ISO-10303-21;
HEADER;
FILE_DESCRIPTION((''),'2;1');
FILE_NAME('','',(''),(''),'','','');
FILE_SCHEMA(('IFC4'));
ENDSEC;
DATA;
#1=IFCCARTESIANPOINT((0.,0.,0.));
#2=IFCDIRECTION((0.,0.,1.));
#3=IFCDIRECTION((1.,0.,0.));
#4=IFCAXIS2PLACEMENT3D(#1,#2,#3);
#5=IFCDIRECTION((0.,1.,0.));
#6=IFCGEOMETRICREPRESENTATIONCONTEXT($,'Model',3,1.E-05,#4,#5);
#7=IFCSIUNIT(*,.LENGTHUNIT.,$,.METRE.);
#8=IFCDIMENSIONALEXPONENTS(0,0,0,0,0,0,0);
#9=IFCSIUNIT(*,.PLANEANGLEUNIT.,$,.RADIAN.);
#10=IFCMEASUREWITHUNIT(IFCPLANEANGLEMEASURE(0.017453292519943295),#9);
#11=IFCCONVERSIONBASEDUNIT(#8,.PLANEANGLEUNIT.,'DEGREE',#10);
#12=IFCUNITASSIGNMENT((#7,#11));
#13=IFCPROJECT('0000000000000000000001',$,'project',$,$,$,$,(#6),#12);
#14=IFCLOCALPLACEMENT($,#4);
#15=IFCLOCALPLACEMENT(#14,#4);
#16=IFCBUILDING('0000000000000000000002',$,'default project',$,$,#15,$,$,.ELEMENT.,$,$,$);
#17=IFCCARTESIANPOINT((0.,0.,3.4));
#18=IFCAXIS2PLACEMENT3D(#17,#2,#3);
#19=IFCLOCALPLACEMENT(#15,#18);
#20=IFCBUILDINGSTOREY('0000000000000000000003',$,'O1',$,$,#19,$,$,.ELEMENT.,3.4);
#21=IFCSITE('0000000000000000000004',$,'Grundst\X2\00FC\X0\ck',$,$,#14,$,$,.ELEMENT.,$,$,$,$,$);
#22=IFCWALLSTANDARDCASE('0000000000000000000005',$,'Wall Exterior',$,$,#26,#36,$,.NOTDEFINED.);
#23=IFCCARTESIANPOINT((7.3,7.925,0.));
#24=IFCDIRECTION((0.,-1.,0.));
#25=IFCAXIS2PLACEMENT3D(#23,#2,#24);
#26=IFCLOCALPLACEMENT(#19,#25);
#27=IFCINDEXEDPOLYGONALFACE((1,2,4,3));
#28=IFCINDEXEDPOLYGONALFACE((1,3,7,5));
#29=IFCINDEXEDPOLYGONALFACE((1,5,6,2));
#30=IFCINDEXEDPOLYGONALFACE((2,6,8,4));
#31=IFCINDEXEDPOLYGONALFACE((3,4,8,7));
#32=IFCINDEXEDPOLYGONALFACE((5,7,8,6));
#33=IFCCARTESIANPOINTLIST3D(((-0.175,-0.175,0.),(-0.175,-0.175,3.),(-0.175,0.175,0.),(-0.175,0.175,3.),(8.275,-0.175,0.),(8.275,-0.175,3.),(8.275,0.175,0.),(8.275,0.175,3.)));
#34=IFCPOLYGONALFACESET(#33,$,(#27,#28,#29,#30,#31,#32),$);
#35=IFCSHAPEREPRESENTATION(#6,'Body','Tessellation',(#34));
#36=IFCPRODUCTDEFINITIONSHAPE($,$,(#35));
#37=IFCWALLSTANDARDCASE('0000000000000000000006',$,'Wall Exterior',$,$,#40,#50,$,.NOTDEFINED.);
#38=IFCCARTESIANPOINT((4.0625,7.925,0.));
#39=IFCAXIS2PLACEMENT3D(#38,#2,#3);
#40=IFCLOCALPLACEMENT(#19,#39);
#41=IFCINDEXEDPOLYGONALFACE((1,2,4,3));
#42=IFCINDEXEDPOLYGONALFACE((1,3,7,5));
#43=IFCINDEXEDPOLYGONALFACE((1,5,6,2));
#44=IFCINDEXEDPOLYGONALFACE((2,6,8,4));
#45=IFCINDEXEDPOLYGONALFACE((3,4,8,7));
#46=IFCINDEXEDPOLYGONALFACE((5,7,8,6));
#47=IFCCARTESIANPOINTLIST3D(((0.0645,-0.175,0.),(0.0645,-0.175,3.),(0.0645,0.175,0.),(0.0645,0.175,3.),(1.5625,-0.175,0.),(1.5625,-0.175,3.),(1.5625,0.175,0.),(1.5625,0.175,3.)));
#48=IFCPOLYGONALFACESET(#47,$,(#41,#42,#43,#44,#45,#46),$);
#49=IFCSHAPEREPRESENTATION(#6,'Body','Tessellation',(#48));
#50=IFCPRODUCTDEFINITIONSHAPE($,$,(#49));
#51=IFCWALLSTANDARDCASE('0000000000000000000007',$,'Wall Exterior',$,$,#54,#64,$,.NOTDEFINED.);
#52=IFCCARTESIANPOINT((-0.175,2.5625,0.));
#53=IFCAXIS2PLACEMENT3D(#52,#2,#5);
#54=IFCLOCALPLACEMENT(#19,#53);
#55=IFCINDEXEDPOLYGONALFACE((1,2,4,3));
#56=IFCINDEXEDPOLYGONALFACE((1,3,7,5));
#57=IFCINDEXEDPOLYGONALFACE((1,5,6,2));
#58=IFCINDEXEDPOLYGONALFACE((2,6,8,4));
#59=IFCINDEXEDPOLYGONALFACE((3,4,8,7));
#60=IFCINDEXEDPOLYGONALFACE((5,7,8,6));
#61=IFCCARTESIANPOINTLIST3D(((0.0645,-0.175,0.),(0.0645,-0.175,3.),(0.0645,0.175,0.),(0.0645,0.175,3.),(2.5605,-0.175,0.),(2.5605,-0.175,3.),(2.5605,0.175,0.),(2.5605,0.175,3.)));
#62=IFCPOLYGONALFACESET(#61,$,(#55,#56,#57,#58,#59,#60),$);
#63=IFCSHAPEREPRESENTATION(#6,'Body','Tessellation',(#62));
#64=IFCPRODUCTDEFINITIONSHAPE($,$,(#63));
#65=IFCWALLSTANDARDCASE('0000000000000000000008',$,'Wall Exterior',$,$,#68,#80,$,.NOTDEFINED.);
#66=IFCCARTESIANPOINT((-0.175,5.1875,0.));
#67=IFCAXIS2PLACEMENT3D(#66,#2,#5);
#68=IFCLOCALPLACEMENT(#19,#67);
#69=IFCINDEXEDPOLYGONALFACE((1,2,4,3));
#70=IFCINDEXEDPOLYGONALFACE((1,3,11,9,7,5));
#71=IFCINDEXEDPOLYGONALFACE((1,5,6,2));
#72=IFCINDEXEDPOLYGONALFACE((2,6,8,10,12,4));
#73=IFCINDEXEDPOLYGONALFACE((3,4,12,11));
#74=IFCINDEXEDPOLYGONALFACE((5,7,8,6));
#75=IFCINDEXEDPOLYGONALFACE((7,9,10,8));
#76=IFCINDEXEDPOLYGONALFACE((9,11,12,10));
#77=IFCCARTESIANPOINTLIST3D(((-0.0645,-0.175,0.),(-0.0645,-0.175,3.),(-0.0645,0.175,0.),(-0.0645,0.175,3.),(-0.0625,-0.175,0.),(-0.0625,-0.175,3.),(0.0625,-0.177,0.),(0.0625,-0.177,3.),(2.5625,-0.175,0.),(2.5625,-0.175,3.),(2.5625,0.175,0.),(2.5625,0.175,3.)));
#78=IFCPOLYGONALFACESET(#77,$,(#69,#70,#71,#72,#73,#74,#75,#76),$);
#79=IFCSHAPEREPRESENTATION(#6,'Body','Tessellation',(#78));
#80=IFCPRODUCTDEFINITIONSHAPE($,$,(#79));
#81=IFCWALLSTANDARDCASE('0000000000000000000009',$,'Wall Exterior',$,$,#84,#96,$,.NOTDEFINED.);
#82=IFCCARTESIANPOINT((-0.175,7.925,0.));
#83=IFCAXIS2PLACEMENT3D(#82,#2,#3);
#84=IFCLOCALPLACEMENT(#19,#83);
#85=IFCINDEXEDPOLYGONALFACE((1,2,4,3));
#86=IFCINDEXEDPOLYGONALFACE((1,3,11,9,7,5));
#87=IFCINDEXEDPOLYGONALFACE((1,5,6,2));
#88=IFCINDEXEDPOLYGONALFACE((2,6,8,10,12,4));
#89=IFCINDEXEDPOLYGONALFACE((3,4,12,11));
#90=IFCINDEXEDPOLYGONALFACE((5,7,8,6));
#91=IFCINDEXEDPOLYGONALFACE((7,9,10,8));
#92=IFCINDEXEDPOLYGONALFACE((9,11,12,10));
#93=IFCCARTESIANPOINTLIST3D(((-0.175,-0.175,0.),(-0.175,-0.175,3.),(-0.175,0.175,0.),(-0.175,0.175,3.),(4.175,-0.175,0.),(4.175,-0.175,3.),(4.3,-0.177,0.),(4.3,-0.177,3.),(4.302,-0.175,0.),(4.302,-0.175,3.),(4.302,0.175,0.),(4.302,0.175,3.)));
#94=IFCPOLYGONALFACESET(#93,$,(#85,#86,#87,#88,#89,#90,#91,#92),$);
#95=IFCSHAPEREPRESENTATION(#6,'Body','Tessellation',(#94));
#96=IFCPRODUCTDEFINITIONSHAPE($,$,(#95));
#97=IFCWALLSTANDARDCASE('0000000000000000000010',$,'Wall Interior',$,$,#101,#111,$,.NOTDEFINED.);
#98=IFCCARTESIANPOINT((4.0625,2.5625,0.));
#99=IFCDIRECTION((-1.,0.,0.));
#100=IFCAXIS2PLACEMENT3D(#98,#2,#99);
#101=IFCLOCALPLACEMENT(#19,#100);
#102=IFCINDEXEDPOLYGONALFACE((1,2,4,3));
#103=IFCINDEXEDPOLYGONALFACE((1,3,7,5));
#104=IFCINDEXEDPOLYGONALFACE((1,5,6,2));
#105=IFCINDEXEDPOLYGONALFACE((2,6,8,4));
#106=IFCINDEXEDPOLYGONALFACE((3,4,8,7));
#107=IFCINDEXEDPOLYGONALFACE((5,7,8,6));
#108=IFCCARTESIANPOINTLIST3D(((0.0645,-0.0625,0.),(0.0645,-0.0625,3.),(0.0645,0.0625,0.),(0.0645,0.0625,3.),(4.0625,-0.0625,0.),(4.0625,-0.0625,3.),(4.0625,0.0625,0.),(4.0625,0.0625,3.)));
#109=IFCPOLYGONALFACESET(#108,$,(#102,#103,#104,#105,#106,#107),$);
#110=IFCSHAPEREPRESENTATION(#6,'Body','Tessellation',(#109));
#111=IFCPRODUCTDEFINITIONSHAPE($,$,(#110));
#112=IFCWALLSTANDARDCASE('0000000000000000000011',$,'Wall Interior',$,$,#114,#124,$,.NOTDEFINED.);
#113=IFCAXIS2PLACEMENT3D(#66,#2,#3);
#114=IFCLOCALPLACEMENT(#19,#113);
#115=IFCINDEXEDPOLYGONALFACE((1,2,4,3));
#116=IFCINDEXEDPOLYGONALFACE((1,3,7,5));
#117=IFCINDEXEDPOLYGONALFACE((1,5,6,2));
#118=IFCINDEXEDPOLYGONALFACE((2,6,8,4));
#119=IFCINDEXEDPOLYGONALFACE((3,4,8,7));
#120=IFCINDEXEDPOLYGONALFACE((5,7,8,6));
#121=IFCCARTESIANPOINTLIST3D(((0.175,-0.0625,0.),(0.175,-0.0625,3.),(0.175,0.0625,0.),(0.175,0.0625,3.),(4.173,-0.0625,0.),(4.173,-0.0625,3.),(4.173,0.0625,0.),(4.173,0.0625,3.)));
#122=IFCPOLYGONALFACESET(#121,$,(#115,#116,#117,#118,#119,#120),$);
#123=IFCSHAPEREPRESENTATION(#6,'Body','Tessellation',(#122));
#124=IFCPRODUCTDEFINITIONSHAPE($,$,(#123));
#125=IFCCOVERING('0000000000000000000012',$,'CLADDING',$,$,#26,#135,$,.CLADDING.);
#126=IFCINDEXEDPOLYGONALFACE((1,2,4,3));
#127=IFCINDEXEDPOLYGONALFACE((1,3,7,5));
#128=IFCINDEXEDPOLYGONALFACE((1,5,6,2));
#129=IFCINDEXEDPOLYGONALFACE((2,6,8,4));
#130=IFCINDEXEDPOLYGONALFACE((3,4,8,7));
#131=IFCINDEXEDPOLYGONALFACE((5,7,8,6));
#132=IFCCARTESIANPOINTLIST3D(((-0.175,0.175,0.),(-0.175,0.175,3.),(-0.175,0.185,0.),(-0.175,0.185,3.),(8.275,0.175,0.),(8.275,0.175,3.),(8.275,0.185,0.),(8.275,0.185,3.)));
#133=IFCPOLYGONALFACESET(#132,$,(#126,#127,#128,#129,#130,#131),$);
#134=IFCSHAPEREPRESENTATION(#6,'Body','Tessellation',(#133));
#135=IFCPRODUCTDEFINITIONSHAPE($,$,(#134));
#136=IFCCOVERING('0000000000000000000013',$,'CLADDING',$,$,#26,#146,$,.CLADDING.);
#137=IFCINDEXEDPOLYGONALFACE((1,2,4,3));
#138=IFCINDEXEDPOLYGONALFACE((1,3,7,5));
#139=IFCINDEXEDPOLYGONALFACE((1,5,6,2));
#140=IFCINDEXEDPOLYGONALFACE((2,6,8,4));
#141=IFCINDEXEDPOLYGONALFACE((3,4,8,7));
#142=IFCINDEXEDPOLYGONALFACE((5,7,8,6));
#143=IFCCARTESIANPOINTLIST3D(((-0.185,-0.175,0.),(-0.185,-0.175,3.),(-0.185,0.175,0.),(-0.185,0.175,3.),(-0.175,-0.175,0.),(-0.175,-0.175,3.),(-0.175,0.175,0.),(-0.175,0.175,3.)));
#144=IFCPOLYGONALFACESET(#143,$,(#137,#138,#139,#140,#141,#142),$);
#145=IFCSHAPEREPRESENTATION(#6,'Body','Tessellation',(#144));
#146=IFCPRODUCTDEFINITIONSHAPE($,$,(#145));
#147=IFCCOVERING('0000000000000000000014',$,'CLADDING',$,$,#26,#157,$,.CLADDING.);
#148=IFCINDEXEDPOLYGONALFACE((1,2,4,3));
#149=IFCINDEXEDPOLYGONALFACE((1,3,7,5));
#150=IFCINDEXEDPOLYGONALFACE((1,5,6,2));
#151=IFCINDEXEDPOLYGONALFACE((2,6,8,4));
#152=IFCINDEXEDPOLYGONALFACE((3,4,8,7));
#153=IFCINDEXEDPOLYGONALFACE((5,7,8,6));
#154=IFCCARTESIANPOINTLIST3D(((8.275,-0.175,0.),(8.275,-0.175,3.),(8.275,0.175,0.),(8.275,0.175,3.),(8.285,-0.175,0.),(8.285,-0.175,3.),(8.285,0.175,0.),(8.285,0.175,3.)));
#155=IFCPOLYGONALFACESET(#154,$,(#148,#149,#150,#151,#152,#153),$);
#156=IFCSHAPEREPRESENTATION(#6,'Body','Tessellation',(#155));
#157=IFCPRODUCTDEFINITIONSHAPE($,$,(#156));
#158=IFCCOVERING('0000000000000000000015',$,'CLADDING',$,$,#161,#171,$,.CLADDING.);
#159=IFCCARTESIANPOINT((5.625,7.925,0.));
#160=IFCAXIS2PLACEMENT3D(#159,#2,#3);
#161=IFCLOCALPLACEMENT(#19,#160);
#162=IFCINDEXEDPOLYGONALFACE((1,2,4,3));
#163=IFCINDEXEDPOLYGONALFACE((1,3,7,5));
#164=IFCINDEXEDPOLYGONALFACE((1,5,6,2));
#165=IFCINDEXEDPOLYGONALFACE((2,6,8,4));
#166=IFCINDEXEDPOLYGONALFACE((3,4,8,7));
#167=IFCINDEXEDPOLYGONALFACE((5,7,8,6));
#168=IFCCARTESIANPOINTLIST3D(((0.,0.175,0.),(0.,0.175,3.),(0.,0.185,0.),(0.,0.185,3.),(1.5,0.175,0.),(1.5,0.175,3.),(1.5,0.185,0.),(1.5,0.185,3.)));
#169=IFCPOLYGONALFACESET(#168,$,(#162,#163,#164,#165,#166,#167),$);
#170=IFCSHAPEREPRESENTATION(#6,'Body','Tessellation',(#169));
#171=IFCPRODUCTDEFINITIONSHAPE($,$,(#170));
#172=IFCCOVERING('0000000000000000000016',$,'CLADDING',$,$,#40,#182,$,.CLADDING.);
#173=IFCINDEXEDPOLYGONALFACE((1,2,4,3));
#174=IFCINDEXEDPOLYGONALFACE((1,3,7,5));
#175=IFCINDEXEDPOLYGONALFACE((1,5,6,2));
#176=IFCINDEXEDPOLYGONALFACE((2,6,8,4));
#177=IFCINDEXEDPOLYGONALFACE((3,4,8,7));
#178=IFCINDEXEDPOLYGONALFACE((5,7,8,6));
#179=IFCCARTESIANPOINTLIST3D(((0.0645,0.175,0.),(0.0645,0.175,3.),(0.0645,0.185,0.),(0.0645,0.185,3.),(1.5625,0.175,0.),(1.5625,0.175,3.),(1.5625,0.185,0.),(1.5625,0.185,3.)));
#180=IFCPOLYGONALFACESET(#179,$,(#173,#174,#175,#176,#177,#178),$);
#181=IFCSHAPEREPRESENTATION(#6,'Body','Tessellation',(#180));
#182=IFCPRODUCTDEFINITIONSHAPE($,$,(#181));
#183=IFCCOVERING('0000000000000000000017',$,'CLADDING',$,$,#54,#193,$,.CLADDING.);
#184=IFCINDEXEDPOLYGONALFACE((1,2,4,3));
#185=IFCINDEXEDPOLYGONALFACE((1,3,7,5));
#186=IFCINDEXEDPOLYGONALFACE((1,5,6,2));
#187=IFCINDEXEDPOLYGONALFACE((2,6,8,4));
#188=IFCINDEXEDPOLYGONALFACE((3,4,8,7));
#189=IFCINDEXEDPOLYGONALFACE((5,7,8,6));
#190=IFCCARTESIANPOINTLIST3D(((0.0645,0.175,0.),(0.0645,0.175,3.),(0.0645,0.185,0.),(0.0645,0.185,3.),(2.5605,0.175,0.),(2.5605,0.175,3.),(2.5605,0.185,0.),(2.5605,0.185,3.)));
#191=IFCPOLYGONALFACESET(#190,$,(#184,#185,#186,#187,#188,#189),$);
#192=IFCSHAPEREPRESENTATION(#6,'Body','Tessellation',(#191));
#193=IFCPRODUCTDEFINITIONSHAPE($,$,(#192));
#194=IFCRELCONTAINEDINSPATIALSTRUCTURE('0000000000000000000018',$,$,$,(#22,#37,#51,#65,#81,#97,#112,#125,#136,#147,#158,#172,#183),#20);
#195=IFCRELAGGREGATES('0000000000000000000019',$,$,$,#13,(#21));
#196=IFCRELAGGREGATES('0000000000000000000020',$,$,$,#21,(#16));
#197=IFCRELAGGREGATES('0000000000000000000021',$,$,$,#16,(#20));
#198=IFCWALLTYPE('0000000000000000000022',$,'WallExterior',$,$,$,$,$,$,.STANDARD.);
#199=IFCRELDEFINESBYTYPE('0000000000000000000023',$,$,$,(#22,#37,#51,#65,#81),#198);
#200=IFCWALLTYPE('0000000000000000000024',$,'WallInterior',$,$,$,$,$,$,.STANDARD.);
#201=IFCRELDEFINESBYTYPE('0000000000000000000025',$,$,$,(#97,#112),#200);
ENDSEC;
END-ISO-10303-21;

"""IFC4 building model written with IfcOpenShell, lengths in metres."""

from ifc_helpers import new_model, entity, si_unit, converted_unit, direction, frame, origin_with_axes, place, context, project, spatial, polyline, outline, extrude, type_object, element, save


model = new_model("IFC4")

# Units and contexts
model_context = context("Model", 3, precision=1e-05, world=origin_with_axes(), true_north=direction((0.0, 1.0, 0.0)))
ifc_project = project(units=[si_unit("LENGTHUNIT", "METRE"), converted_unit("PLANEANGLEUNIT", "DEGREE", entity("IfcPlaneAngleMeasure", 0.017453292519943295), si_unit("PLANEANGLEUNIT", "RADIAN"), dimensions=[0, 0, 0, 0, 0, 0, 0])], contexts=[model_context])

# Site, building, storey
site_placement = place(None, origin_with_axes())
site = spatial("IfcSite", under=ifc_project, at=site_placement, Name="Grundstück", CompositionType="ELEMENT")
building_placement = place(site_placement, origin_with_axes())
building = spatial("IfcBuilding", under=site, at=building_placement, Name="default project", CompositionType="ELEMENT")
placement_1 = place(building_placement, frame((0.0, 0.0, 3.4), z_axis=(0.0, 0.0, 1.0), x_axis=(1.0, 0.0, 0.0)))
storey = spatial("IfcBuildingStorey", under=building, at=placement_1, Name="O1", CompositionType="ELEMENT", Elevation=3.4)

# Walls
wall_type_1 = type_object("IfcWallType", Name="WallExterior", PredefinedType="STANDARD")
placement_2 = place(placement_1, frame((7.3, 7.925, 0.0), z_axis=(0.0, 0.0, 1.0), x_axis=(0.0, -1.0, 0.0)))
element("IfcWallStandardCase", 1, at=placement_2, inside=storey, type_object=wall_type_1, Name="Wall Exterior", PredefinedType="NOTDEFINED", context=model_context, shape_type="SweptSolid", body=[
    extrude(outline(polyline([(8.275, 0.175), (-0.175, 0.175), (-0.175, -0.175), (8.275, -0.175), (8.275, 0.175)])), origin_with_axes(), (0.0, 0.0, 1.0), 3.0),
])
placement_3 = place(placement_1, frame((5.625, 7.925, 0.0), z_axis=(0.0, 0.0, 1.0), x_axis=(1.0, 0.0, 0.0)))
placement_4 = place(placement_1, frame((4.0625, 7.925, 0.0), z_axis=(0.0, 0.0, 1.0), x_axis=(1.0, 0.0, 0.0)))
element("IfcWallStandardCase", 2, at=placement_4, inside=storey, type_object=wall_type_1, Name="Wall Exterior", PredefinedType="NOTDEFINED", context=model_context, shape_type="SweptSolid", body=[
    extrude(outline(polyline([(1.5625, 0.175), (0.0645, 0.175), (0.0645, -0.175), (1.5625, -0.175), (1.5625, 0.175)])), origin_with_axes(), (0.0, 0.0, 1.0), 3.0),
])
placement_5 = place(placement_1, frame((-0.175, 2.5625, 0.0), z_axis=(0.0, 0.0, 1.0), x_axis=(0.0, 1.0, 0.0)))
element("IfcWallStandardCase", 3, at=placement_5, inside=storey, type_object=wall_type_1, Name="Wall Exterior", PredefinedType="NOTDEFINED", context=model_context, shape_type="SweptSolid", body=[
    extrude(outline(polyline([(0.0645, -0.175), (2.5605, -0.175), (2.5605, 0.175), (0.0645, 0.175), (0.0645, -0.175)])), origin_with_axes(), (0.0, 0.0, 1.0), 3.0),
])
placement_6 = place(placement_1, frame((-0.175, 5.1875, 0.0), z_axis=(0.0, 0.0, 1.0), x_axis=(0.0, 1.0, 0.0)))
element("IfcWallStandardCase", 4, at=placement_6, inside=storey, type_object=wall_type_1, Name="Wall Exterior", PredefinedType="NOTDEFINED", context=model_context, shape_type="SweptSolid", body=[
    extrude(outline(polyline([(-0.0625, -0.175), (0.0625, -0.177), (2.5625, -0.175), (2.5625, 0.175), (-0.0645, 0.175), (-0.0645, -0.175), (-0.0625, -0.175)])), origin_with_axes(), (0.0, 0.0, 1.0), 3.0),
])
placement_7 = place(placement_1, frame((-0.175, 7.925, 0.0), z_axis=(0.0, 0.0, 1.0), x_axis=(1.0, 0.0, 0.0)))
element("IfcWallStandardCase", 5, at=placement_7, inside=storey, type_object=wall_type_1, Name="Wall Exterior", PredefinedType="NOTDEFINED", context=model_context, shape_type="SweptSolid", body=[
    extrude(outline(polyline([(-0.175, 0.175), (-0.175, -0.175), (4.175, -0.175), (4.3, -0.177), (4.302, -0.175), (4.302, 0.175), (-0.175, 0.175)])), origin_with_axes(), (0.0, 0.0, 1.0), 3.0),
])
wall_type_2 = type_object("IfcWallType", Name="WallInterior", PredefinedType="STANDARD")
wall_1_placement = place(placement_1, frame((4.0625, 2.5625, 0.0), z_axis=(0.0, 0.0, 1.0), x_axis=(-1.0, 0.0, 0.0)))
element("IfcWallStandardCase", 6, at=wall_1_placement, inside=storey, type_object=wall_type_2, Name="Wall Interior", PredefinedType="NOTDEFINED", context=model_context, shape_type="SweptSolid", body=[
    extrude(outline(polyline([(0.0645, -0.0625), (4.0625, -0.0625), (4.0625, 0.0625), (0.0645, 0.0625), (0.0645, -0.0625)])), origin_with_axes(), (0.0, 0.0, 1.0), 3.0),
])
wall_2_placement = place(placement_1, frame((-0.175, 5.1875, 0.0), z_axis=(0.0, 0.0, 1.0), x_axis=(1.0, 0.0, 0.0)))
element("IfcWallStandardCase", 7, at=wall_2_placement, inside=storey, type_object=wall_type_2, Name="Wall Interior", PredefinedType="NOTDEFINED", context=model_context, shape_type="SweptSolid", body=[
    extrude(outline(polyline([(4.173, 0.0625), (0.175, 0.0625), (0.175, -0.0625), (4.173, -0.0625), (4.173, 0.0625)])), origin_with_axes(), (0.0, 0.0, 1.0), 3.0),
])

# Coverings
element("IfcCovering", 8, at=placement_2, inside=storey, Name="CLADDING", PredefinedType="CLADDING", context=model_context, shape_type="SweptSolid", body=[
    extrude(outline(polyline([(8.275, 0.185), (-0.175, 0.185), (-0.175, 0.175), (8.275, 0.175), (8.275, 0.185)])), origin_with_axes(), (0.0, 0.0, 1.0), 3.0),
])
element("IfcCovering", 9, at=placement_2, inside=storey, Name="CLADDING", PredefinedType="CLADDING", context=model_context, shape_type="SweptSolid", body=[
    extrude(outline(polyline([(-0.185, 0.175), (-0.185, -0.175), (-0.175, -0.175), (-0.175, 0.175), (-0.185, 0.175)])), origin_with_axes(), (0.0, 0.0, 1.0), 3.0),
])
element("IfcCovering", 10, at=placement_2, inside=storey, Name="CLADDING", PredefinedType="CLADDING", context=model_context, shape_type="SweptSolid", body=[
    extrude(outline(polyline([(8.285, -0.175), (8.285, 0.175), (8.275, 0.175), (8.275, -0.175), (8.285, -0.175)])), origin_with_axes(), (0.0, 0.0, 1.0), 3.0),
])
element("IfcCovering", 11, at=placement_3, inside=storey, Name="CLADDING", PredefinedType="CLADDING", context=model_context, shape_type="SweptSolid", body=[
    extrude(outline(polyline([(1.5, 0.185), (0.0, 0.185), (0.0, 0.175), (1.5, 0.175), (1.5, 0.185)])), origin_with_axes(), (0.0, 0.0, 1.0), 3.0),
])
element("IfcCovering", 12, at=placement_4, inside=storey, Name="CLADDING", PredefinedType="CLADDING", context=model_context, shape_type="SweptSolid", body=[
    extrude(outline(polyline([(1.5625, 0.185), (0.0645, 0.185), (0.0645, 0.175), (1.5625, 0.175), (1.5625, 0.185)])), origin_with_axes(), (0.0, 0.0, 1.0), 3.0),
])
element("IfcCovering", 13, at=placement_5, inside=storey, Name="CLADDING", PredefinedType="CLADDING", context=model_context, shape_type="SweptSolid", body=[
    extrude(outline(polyline([(2.5605, 0.185), (0.0645, 0.185), (0.0645, 0.175), (2.5605, 0.175), (2.5605, 0.185)])), origin_with_axes(), (0.0, 0.0, 1.0), 3.0),
])

save(model, "model.ifc")
